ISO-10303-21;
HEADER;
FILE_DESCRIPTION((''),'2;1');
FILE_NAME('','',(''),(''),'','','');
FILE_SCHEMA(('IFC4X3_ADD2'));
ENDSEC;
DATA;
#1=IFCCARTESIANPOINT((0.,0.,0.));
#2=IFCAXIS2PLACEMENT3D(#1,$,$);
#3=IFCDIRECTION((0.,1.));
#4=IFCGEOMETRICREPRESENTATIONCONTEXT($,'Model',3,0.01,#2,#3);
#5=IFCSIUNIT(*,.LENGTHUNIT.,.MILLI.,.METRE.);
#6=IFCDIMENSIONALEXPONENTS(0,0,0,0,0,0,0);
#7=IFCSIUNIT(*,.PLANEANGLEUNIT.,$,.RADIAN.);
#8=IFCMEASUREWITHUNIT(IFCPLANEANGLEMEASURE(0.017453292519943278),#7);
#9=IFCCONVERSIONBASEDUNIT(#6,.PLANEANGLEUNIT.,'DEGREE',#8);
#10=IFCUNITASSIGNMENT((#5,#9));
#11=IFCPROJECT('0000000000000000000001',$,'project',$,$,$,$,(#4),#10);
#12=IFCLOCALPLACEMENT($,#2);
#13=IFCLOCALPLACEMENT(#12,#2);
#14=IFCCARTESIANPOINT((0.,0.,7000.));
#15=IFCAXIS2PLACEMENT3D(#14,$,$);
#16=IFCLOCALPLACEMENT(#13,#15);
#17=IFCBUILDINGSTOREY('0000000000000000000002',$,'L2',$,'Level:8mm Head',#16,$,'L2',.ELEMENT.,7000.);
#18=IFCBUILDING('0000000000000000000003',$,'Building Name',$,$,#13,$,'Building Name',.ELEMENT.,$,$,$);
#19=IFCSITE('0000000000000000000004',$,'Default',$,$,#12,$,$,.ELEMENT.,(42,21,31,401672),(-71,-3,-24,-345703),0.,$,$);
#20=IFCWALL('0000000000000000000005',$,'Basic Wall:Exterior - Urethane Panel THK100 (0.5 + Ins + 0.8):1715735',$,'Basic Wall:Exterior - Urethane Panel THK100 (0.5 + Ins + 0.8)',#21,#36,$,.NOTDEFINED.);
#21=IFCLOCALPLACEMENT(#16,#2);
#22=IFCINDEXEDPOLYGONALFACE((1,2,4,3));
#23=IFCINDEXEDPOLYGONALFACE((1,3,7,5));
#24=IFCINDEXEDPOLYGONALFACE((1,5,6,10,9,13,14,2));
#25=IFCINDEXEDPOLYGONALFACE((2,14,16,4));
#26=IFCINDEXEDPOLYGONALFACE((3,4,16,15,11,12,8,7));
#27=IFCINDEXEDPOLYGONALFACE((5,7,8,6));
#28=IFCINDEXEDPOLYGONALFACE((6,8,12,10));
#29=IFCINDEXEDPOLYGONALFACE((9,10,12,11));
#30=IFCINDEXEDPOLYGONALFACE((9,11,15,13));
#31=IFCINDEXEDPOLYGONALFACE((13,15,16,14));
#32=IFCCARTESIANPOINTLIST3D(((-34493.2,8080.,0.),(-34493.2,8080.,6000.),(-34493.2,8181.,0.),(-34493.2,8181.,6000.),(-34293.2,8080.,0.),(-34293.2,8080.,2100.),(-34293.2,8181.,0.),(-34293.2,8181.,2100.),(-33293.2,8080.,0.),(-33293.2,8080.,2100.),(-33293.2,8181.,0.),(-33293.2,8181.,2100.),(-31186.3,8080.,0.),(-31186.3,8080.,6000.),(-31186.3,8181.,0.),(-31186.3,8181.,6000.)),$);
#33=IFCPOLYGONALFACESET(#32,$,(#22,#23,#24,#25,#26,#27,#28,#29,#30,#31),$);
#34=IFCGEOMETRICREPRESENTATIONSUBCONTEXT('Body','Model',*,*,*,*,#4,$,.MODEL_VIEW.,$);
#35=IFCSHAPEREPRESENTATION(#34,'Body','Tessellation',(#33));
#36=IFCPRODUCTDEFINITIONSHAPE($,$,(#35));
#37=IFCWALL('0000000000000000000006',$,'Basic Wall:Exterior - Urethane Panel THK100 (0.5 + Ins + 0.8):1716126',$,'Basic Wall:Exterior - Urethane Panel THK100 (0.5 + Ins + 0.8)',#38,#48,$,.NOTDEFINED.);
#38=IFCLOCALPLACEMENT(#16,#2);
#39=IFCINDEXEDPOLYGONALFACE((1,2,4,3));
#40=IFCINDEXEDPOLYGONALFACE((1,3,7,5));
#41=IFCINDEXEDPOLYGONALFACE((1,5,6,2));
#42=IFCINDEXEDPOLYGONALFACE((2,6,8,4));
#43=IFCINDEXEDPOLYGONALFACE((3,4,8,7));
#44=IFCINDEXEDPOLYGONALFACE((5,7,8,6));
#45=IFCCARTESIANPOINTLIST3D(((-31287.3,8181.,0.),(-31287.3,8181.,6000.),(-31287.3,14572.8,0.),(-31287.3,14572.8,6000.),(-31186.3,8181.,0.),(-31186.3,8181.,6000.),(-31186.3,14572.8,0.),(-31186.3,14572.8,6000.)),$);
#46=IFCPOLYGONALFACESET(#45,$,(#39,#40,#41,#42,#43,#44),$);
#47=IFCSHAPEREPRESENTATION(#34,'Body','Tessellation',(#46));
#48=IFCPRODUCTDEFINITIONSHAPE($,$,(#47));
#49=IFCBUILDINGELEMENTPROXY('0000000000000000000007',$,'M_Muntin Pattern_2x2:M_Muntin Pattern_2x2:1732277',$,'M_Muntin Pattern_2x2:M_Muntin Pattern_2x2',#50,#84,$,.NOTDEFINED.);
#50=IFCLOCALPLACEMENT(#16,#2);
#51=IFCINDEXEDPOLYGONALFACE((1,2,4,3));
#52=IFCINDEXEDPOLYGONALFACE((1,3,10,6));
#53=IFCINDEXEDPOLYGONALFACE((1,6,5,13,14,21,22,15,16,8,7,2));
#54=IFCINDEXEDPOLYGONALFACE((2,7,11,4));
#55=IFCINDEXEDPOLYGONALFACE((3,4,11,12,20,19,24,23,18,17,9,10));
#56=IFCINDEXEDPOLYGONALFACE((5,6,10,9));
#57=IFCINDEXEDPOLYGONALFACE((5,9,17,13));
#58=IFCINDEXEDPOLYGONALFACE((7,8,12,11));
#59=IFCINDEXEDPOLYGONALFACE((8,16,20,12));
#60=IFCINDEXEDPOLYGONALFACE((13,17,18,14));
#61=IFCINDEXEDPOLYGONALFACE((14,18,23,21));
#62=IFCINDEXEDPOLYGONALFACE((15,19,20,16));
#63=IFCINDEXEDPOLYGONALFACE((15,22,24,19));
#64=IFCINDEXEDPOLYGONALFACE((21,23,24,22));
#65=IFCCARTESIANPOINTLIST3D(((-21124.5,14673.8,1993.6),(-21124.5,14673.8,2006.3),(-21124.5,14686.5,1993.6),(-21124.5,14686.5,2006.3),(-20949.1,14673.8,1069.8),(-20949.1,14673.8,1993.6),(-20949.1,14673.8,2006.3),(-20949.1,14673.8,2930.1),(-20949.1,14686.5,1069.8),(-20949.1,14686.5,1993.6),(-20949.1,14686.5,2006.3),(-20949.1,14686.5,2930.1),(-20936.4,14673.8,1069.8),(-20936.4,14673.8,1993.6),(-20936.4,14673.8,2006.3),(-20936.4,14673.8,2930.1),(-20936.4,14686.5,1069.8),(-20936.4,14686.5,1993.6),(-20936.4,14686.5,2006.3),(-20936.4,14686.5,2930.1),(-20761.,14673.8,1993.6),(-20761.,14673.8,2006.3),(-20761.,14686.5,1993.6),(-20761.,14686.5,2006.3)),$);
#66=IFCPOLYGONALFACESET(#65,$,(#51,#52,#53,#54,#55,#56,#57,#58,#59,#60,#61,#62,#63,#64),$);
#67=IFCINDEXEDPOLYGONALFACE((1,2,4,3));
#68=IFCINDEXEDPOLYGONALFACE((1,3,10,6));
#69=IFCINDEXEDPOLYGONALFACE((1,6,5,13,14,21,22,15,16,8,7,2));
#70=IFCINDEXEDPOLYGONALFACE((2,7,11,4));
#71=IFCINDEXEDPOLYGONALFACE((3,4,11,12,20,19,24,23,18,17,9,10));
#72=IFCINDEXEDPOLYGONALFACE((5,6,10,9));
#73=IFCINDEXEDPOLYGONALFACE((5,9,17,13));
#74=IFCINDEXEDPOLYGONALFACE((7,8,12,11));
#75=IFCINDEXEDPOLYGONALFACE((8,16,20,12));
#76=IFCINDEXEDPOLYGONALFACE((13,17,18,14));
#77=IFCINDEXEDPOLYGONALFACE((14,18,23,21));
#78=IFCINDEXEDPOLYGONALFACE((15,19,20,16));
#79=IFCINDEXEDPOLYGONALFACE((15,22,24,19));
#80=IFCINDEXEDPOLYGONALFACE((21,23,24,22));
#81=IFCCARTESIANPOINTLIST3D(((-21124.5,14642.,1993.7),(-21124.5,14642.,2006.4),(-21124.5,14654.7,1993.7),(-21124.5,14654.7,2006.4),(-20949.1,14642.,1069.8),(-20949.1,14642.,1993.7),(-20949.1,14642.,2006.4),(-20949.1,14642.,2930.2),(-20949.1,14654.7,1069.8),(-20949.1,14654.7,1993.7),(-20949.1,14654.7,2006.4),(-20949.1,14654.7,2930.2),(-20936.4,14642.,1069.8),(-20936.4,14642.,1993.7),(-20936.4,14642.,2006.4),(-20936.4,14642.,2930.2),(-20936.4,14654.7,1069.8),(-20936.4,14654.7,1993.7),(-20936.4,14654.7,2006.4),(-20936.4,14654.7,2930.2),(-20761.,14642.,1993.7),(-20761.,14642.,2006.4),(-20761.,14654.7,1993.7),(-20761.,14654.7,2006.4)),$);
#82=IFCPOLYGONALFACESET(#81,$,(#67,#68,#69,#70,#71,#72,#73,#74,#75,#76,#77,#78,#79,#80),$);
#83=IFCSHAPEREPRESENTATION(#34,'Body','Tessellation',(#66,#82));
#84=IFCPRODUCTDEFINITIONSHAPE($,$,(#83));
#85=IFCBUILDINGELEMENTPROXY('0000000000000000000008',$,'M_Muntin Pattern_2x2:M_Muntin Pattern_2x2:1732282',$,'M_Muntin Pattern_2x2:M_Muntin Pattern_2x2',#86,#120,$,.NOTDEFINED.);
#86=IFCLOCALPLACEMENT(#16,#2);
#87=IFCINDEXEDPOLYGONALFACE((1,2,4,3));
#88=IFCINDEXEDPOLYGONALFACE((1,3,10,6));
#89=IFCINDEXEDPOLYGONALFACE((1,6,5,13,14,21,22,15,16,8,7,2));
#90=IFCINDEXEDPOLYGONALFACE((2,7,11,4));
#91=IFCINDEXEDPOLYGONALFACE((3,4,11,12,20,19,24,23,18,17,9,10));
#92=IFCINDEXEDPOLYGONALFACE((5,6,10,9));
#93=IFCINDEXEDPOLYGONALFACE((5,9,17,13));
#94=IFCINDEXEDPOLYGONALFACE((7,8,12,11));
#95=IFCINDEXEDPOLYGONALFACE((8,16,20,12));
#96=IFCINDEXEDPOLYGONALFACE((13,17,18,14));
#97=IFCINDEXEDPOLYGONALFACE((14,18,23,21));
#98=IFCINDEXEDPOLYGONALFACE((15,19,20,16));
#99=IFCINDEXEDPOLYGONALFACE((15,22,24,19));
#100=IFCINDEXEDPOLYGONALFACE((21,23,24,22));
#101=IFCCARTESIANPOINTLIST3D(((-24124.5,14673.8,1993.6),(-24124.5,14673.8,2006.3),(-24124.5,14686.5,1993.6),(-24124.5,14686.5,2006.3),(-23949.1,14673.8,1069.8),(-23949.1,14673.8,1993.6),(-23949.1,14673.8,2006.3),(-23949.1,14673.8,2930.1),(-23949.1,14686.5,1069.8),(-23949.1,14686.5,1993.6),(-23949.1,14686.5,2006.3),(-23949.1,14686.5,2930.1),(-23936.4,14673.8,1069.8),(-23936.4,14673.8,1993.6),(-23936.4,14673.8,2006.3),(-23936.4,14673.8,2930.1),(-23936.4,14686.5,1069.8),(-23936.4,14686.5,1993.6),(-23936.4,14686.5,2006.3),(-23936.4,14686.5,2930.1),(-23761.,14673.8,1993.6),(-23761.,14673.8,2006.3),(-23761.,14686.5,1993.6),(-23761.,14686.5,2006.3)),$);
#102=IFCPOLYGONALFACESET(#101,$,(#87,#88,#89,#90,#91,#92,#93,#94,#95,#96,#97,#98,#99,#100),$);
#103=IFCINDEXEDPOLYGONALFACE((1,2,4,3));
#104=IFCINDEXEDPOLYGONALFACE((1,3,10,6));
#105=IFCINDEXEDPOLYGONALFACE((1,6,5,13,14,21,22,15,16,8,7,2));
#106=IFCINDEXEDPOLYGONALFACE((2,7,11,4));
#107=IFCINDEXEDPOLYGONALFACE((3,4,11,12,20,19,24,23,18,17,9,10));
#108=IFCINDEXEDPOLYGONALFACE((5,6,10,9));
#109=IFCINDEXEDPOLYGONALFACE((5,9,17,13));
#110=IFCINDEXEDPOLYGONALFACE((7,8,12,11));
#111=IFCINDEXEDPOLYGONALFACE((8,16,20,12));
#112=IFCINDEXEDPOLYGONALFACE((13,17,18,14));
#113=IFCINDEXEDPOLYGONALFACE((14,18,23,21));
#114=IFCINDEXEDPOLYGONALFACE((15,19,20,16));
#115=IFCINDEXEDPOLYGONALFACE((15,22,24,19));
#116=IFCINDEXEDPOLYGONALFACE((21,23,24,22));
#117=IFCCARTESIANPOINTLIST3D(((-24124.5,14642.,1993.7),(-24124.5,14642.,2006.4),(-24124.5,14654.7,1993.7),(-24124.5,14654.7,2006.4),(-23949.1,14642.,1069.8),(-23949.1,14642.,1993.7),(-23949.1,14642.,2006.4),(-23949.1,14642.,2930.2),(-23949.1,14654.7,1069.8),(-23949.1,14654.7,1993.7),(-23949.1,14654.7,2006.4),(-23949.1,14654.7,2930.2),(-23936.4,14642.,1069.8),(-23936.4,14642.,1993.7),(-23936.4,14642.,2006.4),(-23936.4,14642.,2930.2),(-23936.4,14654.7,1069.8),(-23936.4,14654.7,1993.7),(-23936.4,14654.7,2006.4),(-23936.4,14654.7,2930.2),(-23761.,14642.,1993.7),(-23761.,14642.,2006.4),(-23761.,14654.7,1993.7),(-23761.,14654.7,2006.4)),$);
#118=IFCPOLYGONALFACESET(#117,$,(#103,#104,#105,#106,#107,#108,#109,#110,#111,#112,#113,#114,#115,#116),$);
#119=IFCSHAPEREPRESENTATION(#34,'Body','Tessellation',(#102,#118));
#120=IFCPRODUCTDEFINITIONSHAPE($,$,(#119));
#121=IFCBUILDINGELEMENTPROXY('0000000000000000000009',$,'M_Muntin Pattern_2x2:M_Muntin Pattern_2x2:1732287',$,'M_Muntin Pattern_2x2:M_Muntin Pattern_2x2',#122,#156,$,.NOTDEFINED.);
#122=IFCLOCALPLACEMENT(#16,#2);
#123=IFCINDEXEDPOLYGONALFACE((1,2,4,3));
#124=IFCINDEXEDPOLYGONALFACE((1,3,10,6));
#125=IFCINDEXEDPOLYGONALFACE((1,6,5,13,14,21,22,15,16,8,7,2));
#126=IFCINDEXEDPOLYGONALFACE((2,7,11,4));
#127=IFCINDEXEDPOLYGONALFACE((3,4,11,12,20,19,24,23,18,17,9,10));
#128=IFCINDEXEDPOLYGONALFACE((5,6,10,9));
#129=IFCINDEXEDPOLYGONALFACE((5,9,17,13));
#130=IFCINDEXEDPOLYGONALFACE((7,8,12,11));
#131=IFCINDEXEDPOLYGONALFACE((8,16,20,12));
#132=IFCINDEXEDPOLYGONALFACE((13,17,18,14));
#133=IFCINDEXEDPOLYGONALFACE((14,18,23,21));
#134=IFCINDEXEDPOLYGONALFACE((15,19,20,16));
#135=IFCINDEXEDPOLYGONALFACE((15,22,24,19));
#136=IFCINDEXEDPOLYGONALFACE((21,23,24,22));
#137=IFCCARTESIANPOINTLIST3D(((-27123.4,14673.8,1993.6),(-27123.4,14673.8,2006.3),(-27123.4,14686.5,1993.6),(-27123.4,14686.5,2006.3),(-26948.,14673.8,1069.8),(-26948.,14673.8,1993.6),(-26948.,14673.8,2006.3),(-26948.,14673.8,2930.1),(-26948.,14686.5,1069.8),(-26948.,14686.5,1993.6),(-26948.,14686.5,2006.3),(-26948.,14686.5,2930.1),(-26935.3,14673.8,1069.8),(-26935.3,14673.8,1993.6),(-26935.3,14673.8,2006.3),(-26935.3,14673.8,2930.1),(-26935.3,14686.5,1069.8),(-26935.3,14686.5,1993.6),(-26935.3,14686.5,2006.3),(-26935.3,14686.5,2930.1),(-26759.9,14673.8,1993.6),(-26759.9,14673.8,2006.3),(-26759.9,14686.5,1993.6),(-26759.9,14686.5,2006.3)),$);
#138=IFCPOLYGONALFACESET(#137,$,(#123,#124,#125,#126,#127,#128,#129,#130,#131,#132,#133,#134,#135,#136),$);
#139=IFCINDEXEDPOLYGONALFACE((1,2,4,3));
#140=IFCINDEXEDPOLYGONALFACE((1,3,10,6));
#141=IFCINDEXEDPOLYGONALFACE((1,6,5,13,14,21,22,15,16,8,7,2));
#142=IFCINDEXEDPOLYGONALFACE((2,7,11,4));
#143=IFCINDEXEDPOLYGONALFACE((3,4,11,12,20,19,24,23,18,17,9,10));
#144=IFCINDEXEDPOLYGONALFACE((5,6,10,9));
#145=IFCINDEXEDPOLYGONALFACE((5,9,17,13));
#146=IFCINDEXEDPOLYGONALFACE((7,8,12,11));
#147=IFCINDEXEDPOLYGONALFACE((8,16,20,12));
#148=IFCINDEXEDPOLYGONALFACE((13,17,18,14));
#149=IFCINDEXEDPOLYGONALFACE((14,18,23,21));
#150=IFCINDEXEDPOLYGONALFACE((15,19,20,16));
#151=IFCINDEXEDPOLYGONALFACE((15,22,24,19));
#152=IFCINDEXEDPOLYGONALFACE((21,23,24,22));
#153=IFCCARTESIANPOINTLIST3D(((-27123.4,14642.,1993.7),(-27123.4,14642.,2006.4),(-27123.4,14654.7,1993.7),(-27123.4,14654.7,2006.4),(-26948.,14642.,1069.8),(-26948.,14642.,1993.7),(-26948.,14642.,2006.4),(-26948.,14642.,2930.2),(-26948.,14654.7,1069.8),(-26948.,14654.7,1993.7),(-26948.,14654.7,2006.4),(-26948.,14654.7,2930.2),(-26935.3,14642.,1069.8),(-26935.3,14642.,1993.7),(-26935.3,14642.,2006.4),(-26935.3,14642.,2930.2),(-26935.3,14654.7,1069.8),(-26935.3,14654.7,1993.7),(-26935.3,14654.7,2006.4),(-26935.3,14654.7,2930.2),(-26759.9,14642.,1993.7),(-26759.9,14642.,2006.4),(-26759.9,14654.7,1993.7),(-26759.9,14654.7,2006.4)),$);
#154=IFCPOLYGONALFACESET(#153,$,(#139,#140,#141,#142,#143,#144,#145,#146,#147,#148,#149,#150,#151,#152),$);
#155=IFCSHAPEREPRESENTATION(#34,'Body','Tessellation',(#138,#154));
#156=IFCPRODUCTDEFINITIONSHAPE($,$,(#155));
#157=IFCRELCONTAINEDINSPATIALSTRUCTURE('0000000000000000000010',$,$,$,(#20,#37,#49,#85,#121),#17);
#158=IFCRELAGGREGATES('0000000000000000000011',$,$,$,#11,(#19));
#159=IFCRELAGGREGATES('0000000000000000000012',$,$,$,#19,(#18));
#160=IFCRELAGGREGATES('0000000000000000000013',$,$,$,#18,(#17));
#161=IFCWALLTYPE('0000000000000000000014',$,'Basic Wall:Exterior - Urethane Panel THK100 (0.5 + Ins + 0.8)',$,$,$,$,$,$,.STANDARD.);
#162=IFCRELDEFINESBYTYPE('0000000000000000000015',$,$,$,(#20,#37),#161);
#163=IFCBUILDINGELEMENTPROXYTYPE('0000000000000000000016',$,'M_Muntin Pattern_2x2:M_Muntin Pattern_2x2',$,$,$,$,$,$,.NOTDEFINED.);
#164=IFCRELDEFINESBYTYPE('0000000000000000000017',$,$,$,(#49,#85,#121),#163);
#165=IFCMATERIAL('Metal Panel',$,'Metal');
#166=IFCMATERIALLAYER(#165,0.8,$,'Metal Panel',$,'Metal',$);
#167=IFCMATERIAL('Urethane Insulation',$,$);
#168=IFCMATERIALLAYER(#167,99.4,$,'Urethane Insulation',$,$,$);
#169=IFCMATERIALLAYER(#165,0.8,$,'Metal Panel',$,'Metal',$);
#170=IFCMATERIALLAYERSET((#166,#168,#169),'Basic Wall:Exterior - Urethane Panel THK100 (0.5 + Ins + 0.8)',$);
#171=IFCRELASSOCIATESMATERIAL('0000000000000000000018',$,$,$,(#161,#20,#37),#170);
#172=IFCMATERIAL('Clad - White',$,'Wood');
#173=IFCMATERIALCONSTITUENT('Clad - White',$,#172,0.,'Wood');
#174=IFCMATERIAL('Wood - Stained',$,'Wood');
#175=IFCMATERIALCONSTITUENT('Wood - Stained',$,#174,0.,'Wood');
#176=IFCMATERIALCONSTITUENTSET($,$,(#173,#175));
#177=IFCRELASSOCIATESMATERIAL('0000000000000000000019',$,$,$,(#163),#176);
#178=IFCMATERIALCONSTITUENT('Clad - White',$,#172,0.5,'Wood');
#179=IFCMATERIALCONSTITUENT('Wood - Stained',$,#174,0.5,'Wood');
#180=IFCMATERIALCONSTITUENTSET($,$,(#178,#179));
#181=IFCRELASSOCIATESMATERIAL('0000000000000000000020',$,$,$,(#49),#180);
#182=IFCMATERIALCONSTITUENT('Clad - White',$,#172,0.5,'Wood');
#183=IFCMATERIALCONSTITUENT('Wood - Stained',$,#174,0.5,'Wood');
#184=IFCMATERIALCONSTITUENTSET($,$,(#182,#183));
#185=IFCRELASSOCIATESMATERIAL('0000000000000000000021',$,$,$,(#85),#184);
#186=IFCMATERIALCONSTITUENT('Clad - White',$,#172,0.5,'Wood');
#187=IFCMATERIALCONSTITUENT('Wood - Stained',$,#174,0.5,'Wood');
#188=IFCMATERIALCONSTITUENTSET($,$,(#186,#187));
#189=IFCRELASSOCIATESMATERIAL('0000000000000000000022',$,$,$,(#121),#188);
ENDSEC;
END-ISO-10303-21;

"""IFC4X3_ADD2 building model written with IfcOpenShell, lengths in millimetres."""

from ifc_helpers import new_model, entity, si_unit, converted_unit, direction, frame, frame_2d, origin, place, context, subcontext, project, spatial, polyline, rectangle, outline, extrude, source, transform, mapped, material, layer, layer_set, constituent, constituent_set, type_object, type_shapes, element, save


model = new_model("IFC4X3_ADD2")

# Units and contexts
model_context = context("Model", 3, precision=0.01, world=origin(), true_north=direction((0.0, 1.0)))
body_context = subcontext(model_context, "Body", "Model", "MODEL_VIEW")
ifc_project = project(units=[si_unit("LENGTHUNIT", "METRE", prefix="MILLI"), converted_unit("PLANEANGLEUNIT", "DEGREE", entity("IfcPlaneAngleMeasure", 0.017453292519943278), si_unit("PLANEANGLEUNIT", "RADIAN"), dimensions=[0, 0, 0, 0, 0, 0, 0])], contexts=[model_context])

# Site, building, storey
site_placement = place(None, origin())
site = spatial("IfcSite", under=ifc_project, at=site_placement, Name="Default", CompositionType="ELEMENT", RefLatitude=(42, 21, 31, 401672), RefLongitude=(-71, -3, -24, -345703), RefElevation=0.0)
building_placement = place(site_placement, origin())
building = spatial("IfcBuilding", under=site, at=building_placement, Name="Building Name", LongName="Building Name", CompositionType="ELEMENT")
storey_placement = place(building_placement, frame((0.0, 0.0, 7000.0)))
storey = spatial("IfcBuildingStorey", under=building, at=storey_placement, Name="L2", ObjectType="Level:8mm Head", LongName="L2", CompositionType="ELEMENT", Elevation=7000.0)

# Wall, opening
ifc_material_1 = material(Name="Metal Panel", Category="Metal")
ifc_layer_1 = layer(ifc_material_1, 0.8, Name="Metal Panel", Category="Metal")
ifc_material_2 = material(Name="Urethane Insulation")
ifc_layer_2 = layer(ifc_material_2, 99.4, Name="Urethane Insulation")
ifc_layer_3 = layer(ifc_material_1, 0.8, Name="Metal Panel", Category="Metal")
ifc_layer_set = layer_set([ifc_layer_1, ifc_layer_2, ifc_layer_3], Name="Basic Wall:Exterior - Urethane Panel THK100 (0.5 + Ins + 0.8)")
wall_type = type_object("IfcWallType", Name="Basic Wall:Exterior - Urethane Panel THK100 (0.5 + Ins + 0.8)", PredefinedType="STANDARD", material=ifc_layer_set)
wall_1_placement = place(storey_placement, frame((-31186.3, 8130.5, 0.0), z_axis=(0.0, 0.0, 1.0), x_axis=(-1.0, 0.0, 0.0)))
wall_1 = element("IfcWall", 1, at=wall_1_placement, inside=storey, type_object=wall_type, material=ifc_layer_set, Name="Basic Wall:Exterior - Urethane Panel THK100 (0.5 + Ins + 0.8):1715735", ObjectType="Basic Wall:Exterior - Urethane Panel THK100 (0.5 + Ins + 0.8)", PredefinedType="NOTDEFINED", context=body_context, shape_type="SweptSolid", body=[
    extrude(rectangle(XDim=3306.9, YDim=101.0, at=frame_2d((1653.4, 0.0), x_axis=(-1.0, 0.0))), origin(), (0.0, 0.0, 1.0), 6000.0),
])
opening_placement = place(wall_1_placement, frame((2106.9, -50.5, 0.0)))
element("IfcOpeningElement", 2, at=opening_placement, cuts=wall_1, PredefinedType="OPENING", context=body_context, shape_type="SweptSolid", body=[
    extrude(rectangle(XDim=2100.0, YDim=1000.0, at=frame_2d((1050.0, 500.0), x_axis=(1.0, 0.0))), frame((0.0, 0.0, 0.0), z_axis=(0.0, 1.0, 0.0), x_axis=(0.0, 0.0, 1.0)), (0.0, 0.0, 1.0), 101.0),
])

# Wall
wall_2_placement = place(storey_placement, frame((-31236.8, 8181.0, 0.0), z_axis=(0.0, 0.0, 1.0), x_axis=(0.0, 1.0, 0.0)))
element("IfcWall", 3, at=wall_2_placement, inside=storey, type_object=wall_type, material=ifc_layer_set, Name="Basic Wall:Exterior - Urethane Panel THK100 (0.5 + Ins + 0.8):1716126", ObjectType="Basic Wall:Exterior - Urethane Panel THK100 (0.5 + Ins + 0.8)", PredefinedType="NOTDEFINED", context=body_context, shape_type="SweptSolid", body=[
    extrude(rectangle(XDim=6391.8, YDim=101.0, at=frame_2d((3195.9, 0.0), x_axis=(-1.0, 0.0))), origin(), (0.0, 0.0, 1.0), 6000.0),
])

# Building element proxies
ifc_material_3 = material(Name="Clad - White", Category="Wood")
ifc_constituent_1 = constituent(ifc_material_3, Name="Clad - White", Category="Wood", fraction=0.5)
ifc_material_4 = material(Name="Wood - Stained", Category="Wood")
ifc_constituent_2 = constituent(ifc_material_4, Name="Wood - Stained", Category="Wood", fraction=0.5)
ifc_constituent_set_1 = constituent_set(constituents=[ifc_constituent_1, ifc_constituent_2])
ifc_constituent_3 = constituent(ifc_material_3, Name="Clad - White", Category="Wood", fraction=0.0)
ifc_constituent_4 = constituent(ifc_material_4, Name="Wood - Stained", Category="Wood", fraction=0.0)
ifc_constituent_set_2 = constituent_set(constituents=[ifc_constituent_3, ifc_constituent_4])
building_element_proxy_type_1 = type_object("IfcBuildingElementProxyType", Name="M_Muntin Pattern_2x2:M_Muntin Pattern_2x2", PredefinedType="NOTDEFINED", material=ifc_constituent_set_2)
shared_shape_1 = source(origin(), body_context, "Body", "SweptSolid", [
    extrude(outline(polyline([(6.4, -6.4), (930.1, -6.4), (930.1, 6.3), (6.4, 6.3), (6.4, 181.7), (-6.3, 181.7), (-6.3, 6.3), (-930.2, 6.3), (-930.2, -6.4), (-6.3, -6.4), (-6.3, -181.7), (6.4, -181.7), (6.4, -6.4)])), frame((0.0, 9.5, 930.1), z_axis=(0.0, 1.0, 0.0), x_axis=(0.0, 0.0, 1.0)), (0.0, 0.0, 1.0), 12.7),
    extrude(outline(polyline([(6.4, -6.4), (930.2, -6.4), (930.2, 6.3), (6.4, 6.3), (6.4, 181.7), (-6.3, 181.7), (-6.3, 6.3), (-930.2, 6.3), (-930.2, -6.4), (-6.3, -6.4), (-6.3, -181.7), (6.4, -181.7), (6.4, -6.4)])), frame((0.0, -22.2, 930.2), z_axis=(0.0, 1.0, 0.0), x_axis=(0.0, 0.0, 1.0)), (0.0, 0.0, 1.0), 12.7),
])
type_shapes(building_element_proxy_type_1, [shared_shape_1])
proxy_1_placement = place(storey_placement, frame((-20942.8, 14664.3, 1069.8)))
element("IfcBuildingElementProxy", 4, at=proxy_1_placement, inside=storey, type_object=building_element_proxy_type_1, material=ifc_constituent_set_1, Name="M_Muntin Pattern_2x2:M_Muntin Pattern_2x2:1732277", ObjectType="M_Muntin Pattern_2x2:M_Muntin Pattern_2x2", PredefinedType="NOTDEFINED", context=body_context, shape_type="MappedRepresentation", body=[
    mapped(shared_shape_1, transform((0.0, 0.0, 0.0), scale=1.0)),
])
ifc_constituent_5 = constituent(ifc_material_3, Name="Clad - White", Category="Wood", fraction=0.5)
ifc_constituent_6 = constituent(ifc_material_4, Name="Wood - Stained", Category="Wood", fraction=0.5)
ifc_constituent_set_3 = constituent_set(constituents=[ifc_constituent_5, ifc_constituent_6])
proxy_2_placement = place(storey_placement, frame((-23942.8, 14664.3, 1069.8)))
element("IfcBuildingElementProxy", 5, at=proxy_2_placement, inside=storey, type_object=building_element_proxy_type_1, material=ifc_constituent_set_3, Name="M_Muntin Pattern_2x2:M_Muntin Pattern_2x2:1732282", ObjectType="M_Muntin Pattern_2x2:M_Muntin Pattern_2x2", PredefinedType="NOTDEFINED", context=body_context, shape_type="MappedRepresentation", body=[
    mapped(shared_shape_1, transform((0.0, 0.0, 0.0), scale=1.0)),
])
ifc_constituent_7 = constituent(ifc_material_3, Name="Clad - White", Category="Wood", fraction=0.5)
ifc_constituent_8 = constituent(ifc_material_4, Name="Wood - Stained", Category="Wood", fraction=0.5)
ifc_constituent_set_4 = constituent_set(constituents=[ifc_constituent_7, ifc_constituent_8])
proxy_3_placement = place(storey_placement, frame((-26941.6, 14664.3, 1069.8)))
element("IfcBuildingElementProxy", 6, at=proxy_3_placement, inside=storey, type_object=building_element_proxy_type_1, material=ifc_constituent_set_4, Name="M_Muntin Pattern_2x2:M_Muntin Pattern_2x2:1732287", ObjectType="M_Muntin Pattern_2x2:M_Muntin Pattern_2x2", PredefinedType="NOTDEFINED", context=body_context, shape_type="MappedRepresentation", body=[
    mapped(shared_shape_1, transform((0.0, 0.0, 0.0), scale=1.0)),
])

save(model, "model.ifc")
